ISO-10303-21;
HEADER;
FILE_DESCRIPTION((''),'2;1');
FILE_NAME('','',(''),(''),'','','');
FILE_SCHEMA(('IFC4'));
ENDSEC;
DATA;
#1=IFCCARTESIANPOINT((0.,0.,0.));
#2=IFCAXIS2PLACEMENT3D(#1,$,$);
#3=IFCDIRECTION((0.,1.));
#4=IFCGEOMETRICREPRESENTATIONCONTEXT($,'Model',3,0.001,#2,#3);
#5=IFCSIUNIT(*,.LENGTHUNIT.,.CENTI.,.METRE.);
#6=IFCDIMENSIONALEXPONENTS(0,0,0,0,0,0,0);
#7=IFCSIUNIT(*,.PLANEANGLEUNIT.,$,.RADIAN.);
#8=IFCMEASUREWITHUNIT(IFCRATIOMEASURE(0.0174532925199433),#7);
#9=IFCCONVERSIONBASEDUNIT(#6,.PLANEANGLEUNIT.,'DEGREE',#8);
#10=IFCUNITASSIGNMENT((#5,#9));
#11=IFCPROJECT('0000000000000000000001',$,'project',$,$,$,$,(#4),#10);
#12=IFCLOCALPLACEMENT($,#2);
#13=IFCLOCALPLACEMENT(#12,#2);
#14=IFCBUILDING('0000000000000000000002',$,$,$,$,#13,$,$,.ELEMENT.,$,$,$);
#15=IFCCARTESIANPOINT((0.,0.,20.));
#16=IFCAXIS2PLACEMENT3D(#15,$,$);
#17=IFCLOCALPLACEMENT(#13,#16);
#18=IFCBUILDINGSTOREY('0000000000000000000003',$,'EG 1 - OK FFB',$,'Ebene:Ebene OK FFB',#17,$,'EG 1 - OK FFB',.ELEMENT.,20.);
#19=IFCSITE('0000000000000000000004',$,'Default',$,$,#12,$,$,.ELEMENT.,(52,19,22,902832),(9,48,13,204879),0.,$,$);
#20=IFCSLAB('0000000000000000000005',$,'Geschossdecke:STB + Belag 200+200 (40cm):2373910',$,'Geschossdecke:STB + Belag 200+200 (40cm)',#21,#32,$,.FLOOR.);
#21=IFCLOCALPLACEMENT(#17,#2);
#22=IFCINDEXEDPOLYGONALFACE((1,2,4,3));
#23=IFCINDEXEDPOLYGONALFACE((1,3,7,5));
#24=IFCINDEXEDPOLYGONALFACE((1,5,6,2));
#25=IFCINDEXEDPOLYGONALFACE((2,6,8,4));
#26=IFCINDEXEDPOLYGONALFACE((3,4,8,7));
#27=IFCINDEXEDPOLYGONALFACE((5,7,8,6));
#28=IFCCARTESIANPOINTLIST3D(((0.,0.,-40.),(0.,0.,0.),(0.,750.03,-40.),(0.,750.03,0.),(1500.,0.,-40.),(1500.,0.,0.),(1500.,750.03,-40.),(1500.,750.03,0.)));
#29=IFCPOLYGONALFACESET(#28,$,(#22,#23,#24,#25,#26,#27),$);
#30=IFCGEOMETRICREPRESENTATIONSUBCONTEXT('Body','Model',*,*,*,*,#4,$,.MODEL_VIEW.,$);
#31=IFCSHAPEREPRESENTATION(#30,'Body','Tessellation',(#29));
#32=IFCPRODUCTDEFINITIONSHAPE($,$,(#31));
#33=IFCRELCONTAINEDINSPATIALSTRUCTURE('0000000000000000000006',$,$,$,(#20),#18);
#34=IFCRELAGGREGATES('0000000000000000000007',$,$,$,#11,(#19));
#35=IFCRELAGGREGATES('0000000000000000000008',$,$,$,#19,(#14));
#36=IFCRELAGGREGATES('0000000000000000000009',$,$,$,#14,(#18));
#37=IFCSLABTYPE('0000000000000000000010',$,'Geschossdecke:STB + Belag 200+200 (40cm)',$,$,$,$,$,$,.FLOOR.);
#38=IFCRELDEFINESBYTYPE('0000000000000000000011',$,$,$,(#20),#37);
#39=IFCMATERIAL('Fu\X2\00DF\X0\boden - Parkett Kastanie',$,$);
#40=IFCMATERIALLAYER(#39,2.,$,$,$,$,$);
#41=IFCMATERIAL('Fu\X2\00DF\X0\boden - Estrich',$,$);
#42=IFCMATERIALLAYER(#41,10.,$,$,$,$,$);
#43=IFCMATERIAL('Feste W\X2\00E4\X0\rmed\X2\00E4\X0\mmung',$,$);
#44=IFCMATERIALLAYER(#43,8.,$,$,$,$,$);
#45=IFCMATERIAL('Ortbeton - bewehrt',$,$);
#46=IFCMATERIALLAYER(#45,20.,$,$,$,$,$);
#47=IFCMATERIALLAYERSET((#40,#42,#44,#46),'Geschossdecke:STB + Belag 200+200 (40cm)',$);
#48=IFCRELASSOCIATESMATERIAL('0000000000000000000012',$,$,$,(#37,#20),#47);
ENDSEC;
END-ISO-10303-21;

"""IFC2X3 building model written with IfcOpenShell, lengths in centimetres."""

from ifc_helpers import new_model, entity, si_unit, converted_unit, direction, frame, origin, origin_2d_with_axis, place, context, subcontext, project, spatial, rectangle, extrude, material, layer, layer_set, layer_usage, type_object, element, save


model = new_model("IFC2X3")

# Units and contexts
model_context = context("Model", 3, precision=0.001, world=origin(), true_north=direction((0.0, 1.0)))
body_context = subcontext(model_context, "Body", "Model", "MODEL_VIEW")
ifc_project = project(units=[si_unit("LENGTHUNIT", "METRE", prefix="CENTI"), converted_unit("PLANEANGLEUNIT", "DEGREE", entity("IfcRatioMeasure", 0.0174532925199433), si_unit("PLANEANGLEUNIT", "RADIAN"), dimensions=[0, 0, 0, 0, 0, 0, 0])], contexts=[model_context])

# Site, building, storey
site_placement = place(None, frame((0.0, 0.0, 0.0)))
site = spatial("IfcSite", under=ifc_project, at=site_placement, Name="Default", CompositionType="ELEMENT", RefLatitude=(52, 19, 22, 902832), RefLongitude=(9, 48, 13, 204879), RefElevation=0.0)
building_placement = place(site_placement, origin())
building = spatial("IfcBuilding", under=site, at=building_placement, CompositionType="ELEMENT")
storey_placement = place(building_placement, frame((0.0, 0.0, 20.0)))
storey = spatial("IfcBuildingStorey", under=building, at=storey_placement, Name="EG 1 - OK FFB", ObjectType="Ebene:Ebene OK FFB", LongName="EG 1 - OK FFB", CompositionType="ELEMENT", Elevation=20.0)

# Slab
ifc_material_1 = material(Name="Fußboden - Parkett Kastanie")
ifc_layer_1 = layer(ifc_material_1, 2.0)
ifc_material_2 = material(Name="Fußboden - Estrich")
ifc_layer_2 = layer(ifc_material_2, 10.0)
ifc_material_3 = material(Name="Feste Wärmedämmung")
ifc_layer_3 = layer(ifc_material_3, 8.0)
ifc_material_4 = material(Name="Ortbeton - bewehrt")
ifc_layer_4 = layer(ifc_material_4, 20.0)
ifc_layer_set = layer_set([ifc_layer_1, ifc_layer_2, ifc_layer_3, ifc_layer_4], Name="Geschossdecke:STB + Belag 200+200 (40cm)")
ifc_layer_usage = layer_usage(ifc_layer_set, "AXIS3", "POSITIVE", 0.0)
slab_type = type_object("IfcSlabType", Name="Geschossdecke:STB + Belag 200+200 (40cm)", PredefinedType="FLOOR", material=ifc_layer_set)
slab_placement = place(storey_placement, origin())
element("IfcSlab", 1, at=slab_placement, inside=storey, type_object=slab_type, material=ifc_layer_usage, Name="Geschossdecke:STB + Belag 200+200 (40cm):2373910", ObjectType="Geschossdecke:STB + Belag 200+200 (40cm)", PredefinedType="FLOOR", context=body_context, shape_type="SweptSolid", body=[
    extrude(rectangle(XDim=750.03, YDim=1500.0, at=origin_2d_with_axis()), frame((750.0, 375.02, 0.0), z_axis=(0.0, 0.0, -1.0), x_axis=(0.0, 1.0, 0.0)), (0.0, 0.0, 1.0), 40.0),
])

save(model, "model.ifc")
